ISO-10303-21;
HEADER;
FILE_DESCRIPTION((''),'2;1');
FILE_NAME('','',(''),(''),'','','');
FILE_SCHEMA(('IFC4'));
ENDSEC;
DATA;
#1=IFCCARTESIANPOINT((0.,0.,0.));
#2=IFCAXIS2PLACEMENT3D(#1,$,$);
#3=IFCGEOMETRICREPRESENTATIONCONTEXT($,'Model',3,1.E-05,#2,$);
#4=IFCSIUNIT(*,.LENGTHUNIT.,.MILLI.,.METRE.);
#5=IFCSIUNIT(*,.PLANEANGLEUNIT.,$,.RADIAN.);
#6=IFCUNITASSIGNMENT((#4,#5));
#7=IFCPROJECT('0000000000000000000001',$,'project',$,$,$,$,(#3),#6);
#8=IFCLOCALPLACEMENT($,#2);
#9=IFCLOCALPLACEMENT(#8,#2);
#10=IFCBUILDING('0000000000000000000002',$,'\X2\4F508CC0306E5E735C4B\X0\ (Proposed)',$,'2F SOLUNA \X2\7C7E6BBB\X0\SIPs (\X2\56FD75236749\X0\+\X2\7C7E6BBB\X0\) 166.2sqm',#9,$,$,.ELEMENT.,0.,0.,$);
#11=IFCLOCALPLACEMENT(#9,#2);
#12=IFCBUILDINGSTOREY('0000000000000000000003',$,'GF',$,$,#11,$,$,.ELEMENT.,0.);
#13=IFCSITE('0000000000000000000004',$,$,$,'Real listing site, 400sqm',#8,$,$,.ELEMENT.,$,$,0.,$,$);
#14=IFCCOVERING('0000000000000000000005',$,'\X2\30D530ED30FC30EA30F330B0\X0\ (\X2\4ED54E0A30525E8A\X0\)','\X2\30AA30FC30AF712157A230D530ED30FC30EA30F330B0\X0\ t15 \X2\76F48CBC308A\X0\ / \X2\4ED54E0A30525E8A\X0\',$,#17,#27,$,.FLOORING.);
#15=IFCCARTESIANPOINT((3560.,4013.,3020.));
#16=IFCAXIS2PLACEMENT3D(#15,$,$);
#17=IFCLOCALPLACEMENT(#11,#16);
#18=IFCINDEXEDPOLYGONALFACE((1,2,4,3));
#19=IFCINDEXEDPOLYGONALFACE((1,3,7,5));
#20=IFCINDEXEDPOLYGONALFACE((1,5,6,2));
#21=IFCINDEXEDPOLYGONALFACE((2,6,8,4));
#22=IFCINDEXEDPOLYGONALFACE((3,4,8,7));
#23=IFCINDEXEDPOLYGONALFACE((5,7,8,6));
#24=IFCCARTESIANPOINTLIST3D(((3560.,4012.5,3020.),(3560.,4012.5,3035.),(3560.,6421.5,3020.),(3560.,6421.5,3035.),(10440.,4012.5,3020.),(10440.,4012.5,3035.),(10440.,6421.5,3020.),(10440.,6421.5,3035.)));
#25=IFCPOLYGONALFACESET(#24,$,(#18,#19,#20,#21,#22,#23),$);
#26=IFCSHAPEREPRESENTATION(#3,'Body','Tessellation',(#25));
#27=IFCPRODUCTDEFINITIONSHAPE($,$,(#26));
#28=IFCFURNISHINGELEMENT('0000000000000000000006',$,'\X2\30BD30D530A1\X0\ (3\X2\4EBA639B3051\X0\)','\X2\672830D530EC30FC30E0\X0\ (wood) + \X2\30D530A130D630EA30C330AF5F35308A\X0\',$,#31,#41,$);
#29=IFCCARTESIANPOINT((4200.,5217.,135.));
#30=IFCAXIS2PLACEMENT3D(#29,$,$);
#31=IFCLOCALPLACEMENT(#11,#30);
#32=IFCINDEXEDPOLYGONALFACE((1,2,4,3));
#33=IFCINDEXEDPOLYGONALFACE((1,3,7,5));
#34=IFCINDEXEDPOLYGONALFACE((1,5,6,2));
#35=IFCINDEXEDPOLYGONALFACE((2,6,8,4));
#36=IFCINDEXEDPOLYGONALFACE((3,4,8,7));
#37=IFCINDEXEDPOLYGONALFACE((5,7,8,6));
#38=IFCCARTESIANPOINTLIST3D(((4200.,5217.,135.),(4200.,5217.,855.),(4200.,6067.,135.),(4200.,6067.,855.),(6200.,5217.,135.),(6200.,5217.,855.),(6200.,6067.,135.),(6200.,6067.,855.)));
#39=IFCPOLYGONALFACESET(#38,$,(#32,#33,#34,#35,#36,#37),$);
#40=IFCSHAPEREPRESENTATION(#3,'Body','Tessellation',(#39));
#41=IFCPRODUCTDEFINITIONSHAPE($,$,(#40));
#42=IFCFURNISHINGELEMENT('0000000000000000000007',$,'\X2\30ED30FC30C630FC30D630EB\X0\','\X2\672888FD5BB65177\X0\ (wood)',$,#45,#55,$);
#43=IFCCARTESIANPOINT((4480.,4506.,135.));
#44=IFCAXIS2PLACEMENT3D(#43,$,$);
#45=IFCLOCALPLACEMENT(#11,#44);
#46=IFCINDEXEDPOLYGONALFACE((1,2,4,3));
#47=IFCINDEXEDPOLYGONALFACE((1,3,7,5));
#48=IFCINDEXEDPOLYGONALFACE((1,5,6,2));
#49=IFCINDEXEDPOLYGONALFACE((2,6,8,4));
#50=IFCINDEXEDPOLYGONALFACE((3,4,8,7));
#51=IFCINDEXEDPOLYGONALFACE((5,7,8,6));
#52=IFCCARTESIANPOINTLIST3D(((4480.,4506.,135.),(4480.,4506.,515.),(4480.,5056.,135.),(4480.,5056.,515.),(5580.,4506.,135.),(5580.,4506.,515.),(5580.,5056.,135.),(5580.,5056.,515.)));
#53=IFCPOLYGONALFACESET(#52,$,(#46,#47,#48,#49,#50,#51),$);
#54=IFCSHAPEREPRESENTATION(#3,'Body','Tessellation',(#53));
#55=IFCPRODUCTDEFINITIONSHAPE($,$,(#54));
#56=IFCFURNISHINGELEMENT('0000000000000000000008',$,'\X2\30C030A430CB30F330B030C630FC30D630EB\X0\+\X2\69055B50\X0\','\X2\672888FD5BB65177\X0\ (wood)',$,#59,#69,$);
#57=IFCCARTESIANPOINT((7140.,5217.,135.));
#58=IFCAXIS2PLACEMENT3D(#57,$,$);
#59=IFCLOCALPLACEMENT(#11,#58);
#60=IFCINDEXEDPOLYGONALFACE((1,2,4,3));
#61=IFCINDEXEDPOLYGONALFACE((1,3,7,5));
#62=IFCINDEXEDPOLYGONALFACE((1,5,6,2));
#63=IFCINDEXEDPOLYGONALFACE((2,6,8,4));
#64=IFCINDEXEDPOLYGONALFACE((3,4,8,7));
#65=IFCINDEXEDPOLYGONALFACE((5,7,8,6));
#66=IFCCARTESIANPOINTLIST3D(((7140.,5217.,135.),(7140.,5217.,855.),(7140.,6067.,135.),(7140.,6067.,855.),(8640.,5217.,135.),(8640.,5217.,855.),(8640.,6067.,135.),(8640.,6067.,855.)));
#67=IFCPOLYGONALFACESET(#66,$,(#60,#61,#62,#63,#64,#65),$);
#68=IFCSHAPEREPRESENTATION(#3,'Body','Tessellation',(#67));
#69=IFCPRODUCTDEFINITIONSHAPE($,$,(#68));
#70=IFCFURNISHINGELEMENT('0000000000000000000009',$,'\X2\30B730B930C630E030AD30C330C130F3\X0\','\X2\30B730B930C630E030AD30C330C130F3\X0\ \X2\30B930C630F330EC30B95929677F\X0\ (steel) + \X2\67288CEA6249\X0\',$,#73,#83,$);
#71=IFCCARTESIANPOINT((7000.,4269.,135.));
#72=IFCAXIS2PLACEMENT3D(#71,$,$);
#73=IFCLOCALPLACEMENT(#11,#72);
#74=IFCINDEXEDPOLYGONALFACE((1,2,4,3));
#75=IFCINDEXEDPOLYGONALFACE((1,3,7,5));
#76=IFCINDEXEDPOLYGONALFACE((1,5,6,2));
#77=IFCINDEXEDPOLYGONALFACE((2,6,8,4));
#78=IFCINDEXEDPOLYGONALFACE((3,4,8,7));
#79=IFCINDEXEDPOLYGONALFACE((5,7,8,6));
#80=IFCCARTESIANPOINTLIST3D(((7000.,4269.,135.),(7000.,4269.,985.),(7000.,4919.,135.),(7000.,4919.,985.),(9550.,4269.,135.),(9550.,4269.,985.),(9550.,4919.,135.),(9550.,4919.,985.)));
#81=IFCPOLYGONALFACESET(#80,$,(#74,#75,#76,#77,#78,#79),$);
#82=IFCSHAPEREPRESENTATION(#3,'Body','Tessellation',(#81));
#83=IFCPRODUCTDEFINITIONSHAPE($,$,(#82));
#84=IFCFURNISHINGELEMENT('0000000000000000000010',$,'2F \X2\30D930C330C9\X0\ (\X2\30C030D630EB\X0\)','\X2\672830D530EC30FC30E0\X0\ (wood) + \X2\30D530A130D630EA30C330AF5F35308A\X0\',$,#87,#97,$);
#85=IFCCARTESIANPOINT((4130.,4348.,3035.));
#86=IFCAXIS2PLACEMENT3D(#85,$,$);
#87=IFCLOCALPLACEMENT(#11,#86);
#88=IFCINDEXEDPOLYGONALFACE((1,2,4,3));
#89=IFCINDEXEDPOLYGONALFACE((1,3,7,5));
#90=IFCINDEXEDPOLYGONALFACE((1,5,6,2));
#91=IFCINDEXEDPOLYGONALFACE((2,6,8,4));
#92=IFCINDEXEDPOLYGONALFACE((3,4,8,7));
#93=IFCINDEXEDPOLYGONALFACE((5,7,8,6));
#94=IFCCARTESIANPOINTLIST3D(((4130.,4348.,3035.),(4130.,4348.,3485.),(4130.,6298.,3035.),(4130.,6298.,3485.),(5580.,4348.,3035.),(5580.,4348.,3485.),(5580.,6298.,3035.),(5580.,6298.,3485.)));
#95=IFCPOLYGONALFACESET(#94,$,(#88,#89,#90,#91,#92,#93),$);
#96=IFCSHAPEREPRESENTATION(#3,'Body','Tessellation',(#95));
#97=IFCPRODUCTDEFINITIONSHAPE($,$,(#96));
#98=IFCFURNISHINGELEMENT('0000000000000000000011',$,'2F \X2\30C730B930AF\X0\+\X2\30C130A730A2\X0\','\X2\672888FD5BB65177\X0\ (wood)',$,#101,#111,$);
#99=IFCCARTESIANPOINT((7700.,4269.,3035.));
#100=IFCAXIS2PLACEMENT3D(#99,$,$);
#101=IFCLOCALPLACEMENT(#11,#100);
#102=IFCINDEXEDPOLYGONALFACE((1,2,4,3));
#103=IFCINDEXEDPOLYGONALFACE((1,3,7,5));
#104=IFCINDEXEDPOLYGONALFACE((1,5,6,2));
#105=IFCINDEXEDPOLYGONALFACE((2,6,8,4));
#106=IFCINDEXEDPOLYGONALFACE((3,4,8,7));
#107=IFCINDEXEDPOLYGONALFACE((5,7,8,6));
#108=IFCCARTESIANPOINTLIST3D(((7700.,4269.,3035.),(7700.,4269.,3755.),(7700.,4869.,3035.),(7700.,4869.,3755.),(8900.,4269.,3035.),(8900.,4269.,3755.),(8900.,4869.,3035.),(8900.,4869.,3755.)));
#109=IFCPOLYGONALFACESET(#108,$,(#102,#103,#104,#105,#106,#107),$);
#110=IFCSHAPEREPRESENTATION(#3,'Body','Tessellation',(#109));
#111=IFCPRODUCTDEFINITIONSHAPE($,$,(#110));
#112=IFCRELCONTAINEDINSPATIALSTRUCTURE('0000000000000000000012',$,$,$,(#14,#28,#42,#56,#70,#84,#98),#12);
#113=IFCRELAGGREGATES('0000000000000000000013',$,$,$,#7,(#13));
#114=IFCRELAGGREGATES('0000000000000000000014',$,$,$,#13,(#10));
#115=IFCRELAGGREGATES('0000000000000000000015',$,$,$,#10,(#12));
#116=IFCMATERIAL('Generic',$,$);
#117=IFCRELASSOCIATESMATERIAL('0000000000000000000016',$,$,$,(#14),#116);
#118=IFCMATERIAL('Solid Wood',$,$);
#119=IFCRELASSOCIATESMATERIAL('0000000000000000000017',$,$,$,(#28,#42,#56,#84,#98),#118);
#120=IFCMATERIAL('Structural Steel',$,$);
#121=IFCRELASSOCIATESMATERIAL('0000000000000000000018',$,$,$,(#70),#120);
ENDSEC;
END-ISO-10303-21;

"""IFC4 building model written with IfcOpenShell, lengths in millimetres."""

from ifc_helpers import new_model, si_unit, frame, frame_2d, origin, place, context, project, spatial, rectangle, extrude, material, element, save


model = new_model("IFC4")

# Units and contexts
model_context = context("Model", 3, precision=1e-05, world=origin())
ifc_project = project(units=[si_unit("LENGTHUNIT", "METRE", prefix="MILLI"), si_unit("PLANEANGLEUNIT", "RADIAN")], contexts=[model_context])

# Site, building, storey
site_placement = place(None, origin())
site = spatial("IfcSite", under=ifc_project, at=site_placement, ObjectType="Real listing site, 400sqm", CompositionType="ELEMENT", RefElevation=0.0)
building_placement = place(site_placement, origin())
building = spatial("IfcBuilding", under=site, at=building_placement, Name="佐賀の平屋 (Proposed)", ObjectType="2F SOLUNA 籾殻SIPs (国産杉+籾殻) 166.2sqm", CompositionType="ELEMENT", ElevationOfRefHeight=0.0, ElevationOfTerrain=0.0)
storey_placement = place(building_placement, origin())
storey = spatial("IfcBuildingStorey", under=building, at=storey_placement, Name="GF", CompositionType="ELEMENT", Elevation=0.0)

# Shared definitions
ifc_material_1 = material(Name="Solid Wood")

# Shared definitions
ifc_material_2 = material(Name="Generic")

# Shared definitions
ifc_material_3 = material(Name="Structural Steel")

# Covering
covering_placement = place(storey_placement, frame((3560.0, 4013.0, 3020.0)))
element("IfcCovering", 1, at=covering_placement, inside=storey, material=ifc_material_2, Name="フローリング (仕上げ床)", Description="オーク無垢フローリング t15 直貼り / 仕上げ床", PredefinedType="FLOORING", context=model_context, shape_type="SweptSolid", body=[
    extrude(rectangle(XDim=6880.0, YDim=2409.0, at=frame_2d((3440.0, 1204.0))), frame((3560.0, 4013.0, 3020.0)), (0.0, 0.0, 1.0), 15.0),
])

# Furnishing elements
furnishing_1_placement = place(storey_placement, frame((4200.0, 5217.0, 135.0)))
element("IfcFurnishingElement", 2, at=furnishing_1_placement, inside=storey, material=ifc_material_1, Name="ソファ (3人掛け)", Description="木フレーム (wood) + ファブリック張り", context=model_context, shape_type="SweptSolid", body=[
    extrude(rectangle(XDim=2000.0, YDim=850.0, at=frame_2d((1000.0, 425.0))), frame((4200.0, 5217.0, 135.0)), (0.0, 0.0, 1.0), 720.0),
])
furnishing_2_placement = place(storey_placement, frame((4480.0, 4506.0, 135.0)))
element("IfcFurnishingElement", 3, at=furnishing_2_placement, inside=storey, material=ifc_material_1, Name="ローテーブル", Description="木製家具 (wood)", context=model_context, shape_type="SweptSolid", body=[
    extrude(rectangle(XDim=1100.0, YDim=550.0, at=frame_2d((550.0, 275.0))), frame((4480.0, 4506.0, 135.0)), (0.0, 0.0, 1.0), 380.0),
])
furnishing_3_placement = place(storey_placement, frame((7140.0, 5217.0, 135.0)))
element("IfcFurnishingElement", 4, at=furnishing_3_placement, inside=storey, material=ifc_material_1, Name="ダイニングテーブル+椅子", Description="木製家具 (wood)", context=model_context, shape_type="SweptSolid", body=[
    extrude(rectangle(XDim=1500.0, YDim=850.0, at=frame_2d((750.0, 425.0))), frame((7140.0, 5217.0, 135.0)), (0.0, 0.0, 1.0), 720.0),
])
furnishing_4_placement = place(storey_placement, frame((7000.0, 4269.0, 135.0)))
element("IfcFurnishingElement", 5, at=furnishing_4_placement, inside=storey, material=ifc_material_3, Name="システムキッチン", Description="システムキッチン ステンレス天板 (steel) + 木質扉", context=model_context, shape_type="SweptSolid", body=[
    extrude(rectangle(XDim=2550.0, YDim=650.0, at=frame_2d((1275.0, 325.0))), frame((7000.0, 4269.0, 135.0)), (0.0, 0.0, 1.0), 850.0),
])
furnishing_5_placement = place(storey_placement, frame((4130.0, 4348.0, 3035.0)))
element("IfcFurnishingElement", 6, at=furnishing_5_placement, inside=storey, material=ifc_material_1, Name="2F ベッド (ダブル)", Description="木フレーム (wood) + ファブリック張り", context=model_context, shape_type="SweptSolid", body=[
    extrude(rectangle(XDim=1450.0, YDim=1950.0, at=frame_2d((725.0, 975.0))), frame((4130.0, 4348.0, 3035.0)), (0.0, 0.0, 1.0), 450.0),
])
furnishing_6_placement = place(storey_placement, frame((7700.0, 4269.0, 3035.0)))
element("IfcFurnishingElement", 7, at=furnishing_6_placement, inside=storey, material=ifc_material_1, Name="2F デスク+チェア", Description="木製家具 (wood)", context=model_context, shape_type="SweptSolid", body=[
    extrude(rectangle(XDim=1200.0, YDim=600.0, at=frame_2d((600.0, 300.0))), frame((7700.0, 4269.0, 3035.0)), (0.0, 0.0, 1.0), 720.0),
])

save(model, "model.ifc")
